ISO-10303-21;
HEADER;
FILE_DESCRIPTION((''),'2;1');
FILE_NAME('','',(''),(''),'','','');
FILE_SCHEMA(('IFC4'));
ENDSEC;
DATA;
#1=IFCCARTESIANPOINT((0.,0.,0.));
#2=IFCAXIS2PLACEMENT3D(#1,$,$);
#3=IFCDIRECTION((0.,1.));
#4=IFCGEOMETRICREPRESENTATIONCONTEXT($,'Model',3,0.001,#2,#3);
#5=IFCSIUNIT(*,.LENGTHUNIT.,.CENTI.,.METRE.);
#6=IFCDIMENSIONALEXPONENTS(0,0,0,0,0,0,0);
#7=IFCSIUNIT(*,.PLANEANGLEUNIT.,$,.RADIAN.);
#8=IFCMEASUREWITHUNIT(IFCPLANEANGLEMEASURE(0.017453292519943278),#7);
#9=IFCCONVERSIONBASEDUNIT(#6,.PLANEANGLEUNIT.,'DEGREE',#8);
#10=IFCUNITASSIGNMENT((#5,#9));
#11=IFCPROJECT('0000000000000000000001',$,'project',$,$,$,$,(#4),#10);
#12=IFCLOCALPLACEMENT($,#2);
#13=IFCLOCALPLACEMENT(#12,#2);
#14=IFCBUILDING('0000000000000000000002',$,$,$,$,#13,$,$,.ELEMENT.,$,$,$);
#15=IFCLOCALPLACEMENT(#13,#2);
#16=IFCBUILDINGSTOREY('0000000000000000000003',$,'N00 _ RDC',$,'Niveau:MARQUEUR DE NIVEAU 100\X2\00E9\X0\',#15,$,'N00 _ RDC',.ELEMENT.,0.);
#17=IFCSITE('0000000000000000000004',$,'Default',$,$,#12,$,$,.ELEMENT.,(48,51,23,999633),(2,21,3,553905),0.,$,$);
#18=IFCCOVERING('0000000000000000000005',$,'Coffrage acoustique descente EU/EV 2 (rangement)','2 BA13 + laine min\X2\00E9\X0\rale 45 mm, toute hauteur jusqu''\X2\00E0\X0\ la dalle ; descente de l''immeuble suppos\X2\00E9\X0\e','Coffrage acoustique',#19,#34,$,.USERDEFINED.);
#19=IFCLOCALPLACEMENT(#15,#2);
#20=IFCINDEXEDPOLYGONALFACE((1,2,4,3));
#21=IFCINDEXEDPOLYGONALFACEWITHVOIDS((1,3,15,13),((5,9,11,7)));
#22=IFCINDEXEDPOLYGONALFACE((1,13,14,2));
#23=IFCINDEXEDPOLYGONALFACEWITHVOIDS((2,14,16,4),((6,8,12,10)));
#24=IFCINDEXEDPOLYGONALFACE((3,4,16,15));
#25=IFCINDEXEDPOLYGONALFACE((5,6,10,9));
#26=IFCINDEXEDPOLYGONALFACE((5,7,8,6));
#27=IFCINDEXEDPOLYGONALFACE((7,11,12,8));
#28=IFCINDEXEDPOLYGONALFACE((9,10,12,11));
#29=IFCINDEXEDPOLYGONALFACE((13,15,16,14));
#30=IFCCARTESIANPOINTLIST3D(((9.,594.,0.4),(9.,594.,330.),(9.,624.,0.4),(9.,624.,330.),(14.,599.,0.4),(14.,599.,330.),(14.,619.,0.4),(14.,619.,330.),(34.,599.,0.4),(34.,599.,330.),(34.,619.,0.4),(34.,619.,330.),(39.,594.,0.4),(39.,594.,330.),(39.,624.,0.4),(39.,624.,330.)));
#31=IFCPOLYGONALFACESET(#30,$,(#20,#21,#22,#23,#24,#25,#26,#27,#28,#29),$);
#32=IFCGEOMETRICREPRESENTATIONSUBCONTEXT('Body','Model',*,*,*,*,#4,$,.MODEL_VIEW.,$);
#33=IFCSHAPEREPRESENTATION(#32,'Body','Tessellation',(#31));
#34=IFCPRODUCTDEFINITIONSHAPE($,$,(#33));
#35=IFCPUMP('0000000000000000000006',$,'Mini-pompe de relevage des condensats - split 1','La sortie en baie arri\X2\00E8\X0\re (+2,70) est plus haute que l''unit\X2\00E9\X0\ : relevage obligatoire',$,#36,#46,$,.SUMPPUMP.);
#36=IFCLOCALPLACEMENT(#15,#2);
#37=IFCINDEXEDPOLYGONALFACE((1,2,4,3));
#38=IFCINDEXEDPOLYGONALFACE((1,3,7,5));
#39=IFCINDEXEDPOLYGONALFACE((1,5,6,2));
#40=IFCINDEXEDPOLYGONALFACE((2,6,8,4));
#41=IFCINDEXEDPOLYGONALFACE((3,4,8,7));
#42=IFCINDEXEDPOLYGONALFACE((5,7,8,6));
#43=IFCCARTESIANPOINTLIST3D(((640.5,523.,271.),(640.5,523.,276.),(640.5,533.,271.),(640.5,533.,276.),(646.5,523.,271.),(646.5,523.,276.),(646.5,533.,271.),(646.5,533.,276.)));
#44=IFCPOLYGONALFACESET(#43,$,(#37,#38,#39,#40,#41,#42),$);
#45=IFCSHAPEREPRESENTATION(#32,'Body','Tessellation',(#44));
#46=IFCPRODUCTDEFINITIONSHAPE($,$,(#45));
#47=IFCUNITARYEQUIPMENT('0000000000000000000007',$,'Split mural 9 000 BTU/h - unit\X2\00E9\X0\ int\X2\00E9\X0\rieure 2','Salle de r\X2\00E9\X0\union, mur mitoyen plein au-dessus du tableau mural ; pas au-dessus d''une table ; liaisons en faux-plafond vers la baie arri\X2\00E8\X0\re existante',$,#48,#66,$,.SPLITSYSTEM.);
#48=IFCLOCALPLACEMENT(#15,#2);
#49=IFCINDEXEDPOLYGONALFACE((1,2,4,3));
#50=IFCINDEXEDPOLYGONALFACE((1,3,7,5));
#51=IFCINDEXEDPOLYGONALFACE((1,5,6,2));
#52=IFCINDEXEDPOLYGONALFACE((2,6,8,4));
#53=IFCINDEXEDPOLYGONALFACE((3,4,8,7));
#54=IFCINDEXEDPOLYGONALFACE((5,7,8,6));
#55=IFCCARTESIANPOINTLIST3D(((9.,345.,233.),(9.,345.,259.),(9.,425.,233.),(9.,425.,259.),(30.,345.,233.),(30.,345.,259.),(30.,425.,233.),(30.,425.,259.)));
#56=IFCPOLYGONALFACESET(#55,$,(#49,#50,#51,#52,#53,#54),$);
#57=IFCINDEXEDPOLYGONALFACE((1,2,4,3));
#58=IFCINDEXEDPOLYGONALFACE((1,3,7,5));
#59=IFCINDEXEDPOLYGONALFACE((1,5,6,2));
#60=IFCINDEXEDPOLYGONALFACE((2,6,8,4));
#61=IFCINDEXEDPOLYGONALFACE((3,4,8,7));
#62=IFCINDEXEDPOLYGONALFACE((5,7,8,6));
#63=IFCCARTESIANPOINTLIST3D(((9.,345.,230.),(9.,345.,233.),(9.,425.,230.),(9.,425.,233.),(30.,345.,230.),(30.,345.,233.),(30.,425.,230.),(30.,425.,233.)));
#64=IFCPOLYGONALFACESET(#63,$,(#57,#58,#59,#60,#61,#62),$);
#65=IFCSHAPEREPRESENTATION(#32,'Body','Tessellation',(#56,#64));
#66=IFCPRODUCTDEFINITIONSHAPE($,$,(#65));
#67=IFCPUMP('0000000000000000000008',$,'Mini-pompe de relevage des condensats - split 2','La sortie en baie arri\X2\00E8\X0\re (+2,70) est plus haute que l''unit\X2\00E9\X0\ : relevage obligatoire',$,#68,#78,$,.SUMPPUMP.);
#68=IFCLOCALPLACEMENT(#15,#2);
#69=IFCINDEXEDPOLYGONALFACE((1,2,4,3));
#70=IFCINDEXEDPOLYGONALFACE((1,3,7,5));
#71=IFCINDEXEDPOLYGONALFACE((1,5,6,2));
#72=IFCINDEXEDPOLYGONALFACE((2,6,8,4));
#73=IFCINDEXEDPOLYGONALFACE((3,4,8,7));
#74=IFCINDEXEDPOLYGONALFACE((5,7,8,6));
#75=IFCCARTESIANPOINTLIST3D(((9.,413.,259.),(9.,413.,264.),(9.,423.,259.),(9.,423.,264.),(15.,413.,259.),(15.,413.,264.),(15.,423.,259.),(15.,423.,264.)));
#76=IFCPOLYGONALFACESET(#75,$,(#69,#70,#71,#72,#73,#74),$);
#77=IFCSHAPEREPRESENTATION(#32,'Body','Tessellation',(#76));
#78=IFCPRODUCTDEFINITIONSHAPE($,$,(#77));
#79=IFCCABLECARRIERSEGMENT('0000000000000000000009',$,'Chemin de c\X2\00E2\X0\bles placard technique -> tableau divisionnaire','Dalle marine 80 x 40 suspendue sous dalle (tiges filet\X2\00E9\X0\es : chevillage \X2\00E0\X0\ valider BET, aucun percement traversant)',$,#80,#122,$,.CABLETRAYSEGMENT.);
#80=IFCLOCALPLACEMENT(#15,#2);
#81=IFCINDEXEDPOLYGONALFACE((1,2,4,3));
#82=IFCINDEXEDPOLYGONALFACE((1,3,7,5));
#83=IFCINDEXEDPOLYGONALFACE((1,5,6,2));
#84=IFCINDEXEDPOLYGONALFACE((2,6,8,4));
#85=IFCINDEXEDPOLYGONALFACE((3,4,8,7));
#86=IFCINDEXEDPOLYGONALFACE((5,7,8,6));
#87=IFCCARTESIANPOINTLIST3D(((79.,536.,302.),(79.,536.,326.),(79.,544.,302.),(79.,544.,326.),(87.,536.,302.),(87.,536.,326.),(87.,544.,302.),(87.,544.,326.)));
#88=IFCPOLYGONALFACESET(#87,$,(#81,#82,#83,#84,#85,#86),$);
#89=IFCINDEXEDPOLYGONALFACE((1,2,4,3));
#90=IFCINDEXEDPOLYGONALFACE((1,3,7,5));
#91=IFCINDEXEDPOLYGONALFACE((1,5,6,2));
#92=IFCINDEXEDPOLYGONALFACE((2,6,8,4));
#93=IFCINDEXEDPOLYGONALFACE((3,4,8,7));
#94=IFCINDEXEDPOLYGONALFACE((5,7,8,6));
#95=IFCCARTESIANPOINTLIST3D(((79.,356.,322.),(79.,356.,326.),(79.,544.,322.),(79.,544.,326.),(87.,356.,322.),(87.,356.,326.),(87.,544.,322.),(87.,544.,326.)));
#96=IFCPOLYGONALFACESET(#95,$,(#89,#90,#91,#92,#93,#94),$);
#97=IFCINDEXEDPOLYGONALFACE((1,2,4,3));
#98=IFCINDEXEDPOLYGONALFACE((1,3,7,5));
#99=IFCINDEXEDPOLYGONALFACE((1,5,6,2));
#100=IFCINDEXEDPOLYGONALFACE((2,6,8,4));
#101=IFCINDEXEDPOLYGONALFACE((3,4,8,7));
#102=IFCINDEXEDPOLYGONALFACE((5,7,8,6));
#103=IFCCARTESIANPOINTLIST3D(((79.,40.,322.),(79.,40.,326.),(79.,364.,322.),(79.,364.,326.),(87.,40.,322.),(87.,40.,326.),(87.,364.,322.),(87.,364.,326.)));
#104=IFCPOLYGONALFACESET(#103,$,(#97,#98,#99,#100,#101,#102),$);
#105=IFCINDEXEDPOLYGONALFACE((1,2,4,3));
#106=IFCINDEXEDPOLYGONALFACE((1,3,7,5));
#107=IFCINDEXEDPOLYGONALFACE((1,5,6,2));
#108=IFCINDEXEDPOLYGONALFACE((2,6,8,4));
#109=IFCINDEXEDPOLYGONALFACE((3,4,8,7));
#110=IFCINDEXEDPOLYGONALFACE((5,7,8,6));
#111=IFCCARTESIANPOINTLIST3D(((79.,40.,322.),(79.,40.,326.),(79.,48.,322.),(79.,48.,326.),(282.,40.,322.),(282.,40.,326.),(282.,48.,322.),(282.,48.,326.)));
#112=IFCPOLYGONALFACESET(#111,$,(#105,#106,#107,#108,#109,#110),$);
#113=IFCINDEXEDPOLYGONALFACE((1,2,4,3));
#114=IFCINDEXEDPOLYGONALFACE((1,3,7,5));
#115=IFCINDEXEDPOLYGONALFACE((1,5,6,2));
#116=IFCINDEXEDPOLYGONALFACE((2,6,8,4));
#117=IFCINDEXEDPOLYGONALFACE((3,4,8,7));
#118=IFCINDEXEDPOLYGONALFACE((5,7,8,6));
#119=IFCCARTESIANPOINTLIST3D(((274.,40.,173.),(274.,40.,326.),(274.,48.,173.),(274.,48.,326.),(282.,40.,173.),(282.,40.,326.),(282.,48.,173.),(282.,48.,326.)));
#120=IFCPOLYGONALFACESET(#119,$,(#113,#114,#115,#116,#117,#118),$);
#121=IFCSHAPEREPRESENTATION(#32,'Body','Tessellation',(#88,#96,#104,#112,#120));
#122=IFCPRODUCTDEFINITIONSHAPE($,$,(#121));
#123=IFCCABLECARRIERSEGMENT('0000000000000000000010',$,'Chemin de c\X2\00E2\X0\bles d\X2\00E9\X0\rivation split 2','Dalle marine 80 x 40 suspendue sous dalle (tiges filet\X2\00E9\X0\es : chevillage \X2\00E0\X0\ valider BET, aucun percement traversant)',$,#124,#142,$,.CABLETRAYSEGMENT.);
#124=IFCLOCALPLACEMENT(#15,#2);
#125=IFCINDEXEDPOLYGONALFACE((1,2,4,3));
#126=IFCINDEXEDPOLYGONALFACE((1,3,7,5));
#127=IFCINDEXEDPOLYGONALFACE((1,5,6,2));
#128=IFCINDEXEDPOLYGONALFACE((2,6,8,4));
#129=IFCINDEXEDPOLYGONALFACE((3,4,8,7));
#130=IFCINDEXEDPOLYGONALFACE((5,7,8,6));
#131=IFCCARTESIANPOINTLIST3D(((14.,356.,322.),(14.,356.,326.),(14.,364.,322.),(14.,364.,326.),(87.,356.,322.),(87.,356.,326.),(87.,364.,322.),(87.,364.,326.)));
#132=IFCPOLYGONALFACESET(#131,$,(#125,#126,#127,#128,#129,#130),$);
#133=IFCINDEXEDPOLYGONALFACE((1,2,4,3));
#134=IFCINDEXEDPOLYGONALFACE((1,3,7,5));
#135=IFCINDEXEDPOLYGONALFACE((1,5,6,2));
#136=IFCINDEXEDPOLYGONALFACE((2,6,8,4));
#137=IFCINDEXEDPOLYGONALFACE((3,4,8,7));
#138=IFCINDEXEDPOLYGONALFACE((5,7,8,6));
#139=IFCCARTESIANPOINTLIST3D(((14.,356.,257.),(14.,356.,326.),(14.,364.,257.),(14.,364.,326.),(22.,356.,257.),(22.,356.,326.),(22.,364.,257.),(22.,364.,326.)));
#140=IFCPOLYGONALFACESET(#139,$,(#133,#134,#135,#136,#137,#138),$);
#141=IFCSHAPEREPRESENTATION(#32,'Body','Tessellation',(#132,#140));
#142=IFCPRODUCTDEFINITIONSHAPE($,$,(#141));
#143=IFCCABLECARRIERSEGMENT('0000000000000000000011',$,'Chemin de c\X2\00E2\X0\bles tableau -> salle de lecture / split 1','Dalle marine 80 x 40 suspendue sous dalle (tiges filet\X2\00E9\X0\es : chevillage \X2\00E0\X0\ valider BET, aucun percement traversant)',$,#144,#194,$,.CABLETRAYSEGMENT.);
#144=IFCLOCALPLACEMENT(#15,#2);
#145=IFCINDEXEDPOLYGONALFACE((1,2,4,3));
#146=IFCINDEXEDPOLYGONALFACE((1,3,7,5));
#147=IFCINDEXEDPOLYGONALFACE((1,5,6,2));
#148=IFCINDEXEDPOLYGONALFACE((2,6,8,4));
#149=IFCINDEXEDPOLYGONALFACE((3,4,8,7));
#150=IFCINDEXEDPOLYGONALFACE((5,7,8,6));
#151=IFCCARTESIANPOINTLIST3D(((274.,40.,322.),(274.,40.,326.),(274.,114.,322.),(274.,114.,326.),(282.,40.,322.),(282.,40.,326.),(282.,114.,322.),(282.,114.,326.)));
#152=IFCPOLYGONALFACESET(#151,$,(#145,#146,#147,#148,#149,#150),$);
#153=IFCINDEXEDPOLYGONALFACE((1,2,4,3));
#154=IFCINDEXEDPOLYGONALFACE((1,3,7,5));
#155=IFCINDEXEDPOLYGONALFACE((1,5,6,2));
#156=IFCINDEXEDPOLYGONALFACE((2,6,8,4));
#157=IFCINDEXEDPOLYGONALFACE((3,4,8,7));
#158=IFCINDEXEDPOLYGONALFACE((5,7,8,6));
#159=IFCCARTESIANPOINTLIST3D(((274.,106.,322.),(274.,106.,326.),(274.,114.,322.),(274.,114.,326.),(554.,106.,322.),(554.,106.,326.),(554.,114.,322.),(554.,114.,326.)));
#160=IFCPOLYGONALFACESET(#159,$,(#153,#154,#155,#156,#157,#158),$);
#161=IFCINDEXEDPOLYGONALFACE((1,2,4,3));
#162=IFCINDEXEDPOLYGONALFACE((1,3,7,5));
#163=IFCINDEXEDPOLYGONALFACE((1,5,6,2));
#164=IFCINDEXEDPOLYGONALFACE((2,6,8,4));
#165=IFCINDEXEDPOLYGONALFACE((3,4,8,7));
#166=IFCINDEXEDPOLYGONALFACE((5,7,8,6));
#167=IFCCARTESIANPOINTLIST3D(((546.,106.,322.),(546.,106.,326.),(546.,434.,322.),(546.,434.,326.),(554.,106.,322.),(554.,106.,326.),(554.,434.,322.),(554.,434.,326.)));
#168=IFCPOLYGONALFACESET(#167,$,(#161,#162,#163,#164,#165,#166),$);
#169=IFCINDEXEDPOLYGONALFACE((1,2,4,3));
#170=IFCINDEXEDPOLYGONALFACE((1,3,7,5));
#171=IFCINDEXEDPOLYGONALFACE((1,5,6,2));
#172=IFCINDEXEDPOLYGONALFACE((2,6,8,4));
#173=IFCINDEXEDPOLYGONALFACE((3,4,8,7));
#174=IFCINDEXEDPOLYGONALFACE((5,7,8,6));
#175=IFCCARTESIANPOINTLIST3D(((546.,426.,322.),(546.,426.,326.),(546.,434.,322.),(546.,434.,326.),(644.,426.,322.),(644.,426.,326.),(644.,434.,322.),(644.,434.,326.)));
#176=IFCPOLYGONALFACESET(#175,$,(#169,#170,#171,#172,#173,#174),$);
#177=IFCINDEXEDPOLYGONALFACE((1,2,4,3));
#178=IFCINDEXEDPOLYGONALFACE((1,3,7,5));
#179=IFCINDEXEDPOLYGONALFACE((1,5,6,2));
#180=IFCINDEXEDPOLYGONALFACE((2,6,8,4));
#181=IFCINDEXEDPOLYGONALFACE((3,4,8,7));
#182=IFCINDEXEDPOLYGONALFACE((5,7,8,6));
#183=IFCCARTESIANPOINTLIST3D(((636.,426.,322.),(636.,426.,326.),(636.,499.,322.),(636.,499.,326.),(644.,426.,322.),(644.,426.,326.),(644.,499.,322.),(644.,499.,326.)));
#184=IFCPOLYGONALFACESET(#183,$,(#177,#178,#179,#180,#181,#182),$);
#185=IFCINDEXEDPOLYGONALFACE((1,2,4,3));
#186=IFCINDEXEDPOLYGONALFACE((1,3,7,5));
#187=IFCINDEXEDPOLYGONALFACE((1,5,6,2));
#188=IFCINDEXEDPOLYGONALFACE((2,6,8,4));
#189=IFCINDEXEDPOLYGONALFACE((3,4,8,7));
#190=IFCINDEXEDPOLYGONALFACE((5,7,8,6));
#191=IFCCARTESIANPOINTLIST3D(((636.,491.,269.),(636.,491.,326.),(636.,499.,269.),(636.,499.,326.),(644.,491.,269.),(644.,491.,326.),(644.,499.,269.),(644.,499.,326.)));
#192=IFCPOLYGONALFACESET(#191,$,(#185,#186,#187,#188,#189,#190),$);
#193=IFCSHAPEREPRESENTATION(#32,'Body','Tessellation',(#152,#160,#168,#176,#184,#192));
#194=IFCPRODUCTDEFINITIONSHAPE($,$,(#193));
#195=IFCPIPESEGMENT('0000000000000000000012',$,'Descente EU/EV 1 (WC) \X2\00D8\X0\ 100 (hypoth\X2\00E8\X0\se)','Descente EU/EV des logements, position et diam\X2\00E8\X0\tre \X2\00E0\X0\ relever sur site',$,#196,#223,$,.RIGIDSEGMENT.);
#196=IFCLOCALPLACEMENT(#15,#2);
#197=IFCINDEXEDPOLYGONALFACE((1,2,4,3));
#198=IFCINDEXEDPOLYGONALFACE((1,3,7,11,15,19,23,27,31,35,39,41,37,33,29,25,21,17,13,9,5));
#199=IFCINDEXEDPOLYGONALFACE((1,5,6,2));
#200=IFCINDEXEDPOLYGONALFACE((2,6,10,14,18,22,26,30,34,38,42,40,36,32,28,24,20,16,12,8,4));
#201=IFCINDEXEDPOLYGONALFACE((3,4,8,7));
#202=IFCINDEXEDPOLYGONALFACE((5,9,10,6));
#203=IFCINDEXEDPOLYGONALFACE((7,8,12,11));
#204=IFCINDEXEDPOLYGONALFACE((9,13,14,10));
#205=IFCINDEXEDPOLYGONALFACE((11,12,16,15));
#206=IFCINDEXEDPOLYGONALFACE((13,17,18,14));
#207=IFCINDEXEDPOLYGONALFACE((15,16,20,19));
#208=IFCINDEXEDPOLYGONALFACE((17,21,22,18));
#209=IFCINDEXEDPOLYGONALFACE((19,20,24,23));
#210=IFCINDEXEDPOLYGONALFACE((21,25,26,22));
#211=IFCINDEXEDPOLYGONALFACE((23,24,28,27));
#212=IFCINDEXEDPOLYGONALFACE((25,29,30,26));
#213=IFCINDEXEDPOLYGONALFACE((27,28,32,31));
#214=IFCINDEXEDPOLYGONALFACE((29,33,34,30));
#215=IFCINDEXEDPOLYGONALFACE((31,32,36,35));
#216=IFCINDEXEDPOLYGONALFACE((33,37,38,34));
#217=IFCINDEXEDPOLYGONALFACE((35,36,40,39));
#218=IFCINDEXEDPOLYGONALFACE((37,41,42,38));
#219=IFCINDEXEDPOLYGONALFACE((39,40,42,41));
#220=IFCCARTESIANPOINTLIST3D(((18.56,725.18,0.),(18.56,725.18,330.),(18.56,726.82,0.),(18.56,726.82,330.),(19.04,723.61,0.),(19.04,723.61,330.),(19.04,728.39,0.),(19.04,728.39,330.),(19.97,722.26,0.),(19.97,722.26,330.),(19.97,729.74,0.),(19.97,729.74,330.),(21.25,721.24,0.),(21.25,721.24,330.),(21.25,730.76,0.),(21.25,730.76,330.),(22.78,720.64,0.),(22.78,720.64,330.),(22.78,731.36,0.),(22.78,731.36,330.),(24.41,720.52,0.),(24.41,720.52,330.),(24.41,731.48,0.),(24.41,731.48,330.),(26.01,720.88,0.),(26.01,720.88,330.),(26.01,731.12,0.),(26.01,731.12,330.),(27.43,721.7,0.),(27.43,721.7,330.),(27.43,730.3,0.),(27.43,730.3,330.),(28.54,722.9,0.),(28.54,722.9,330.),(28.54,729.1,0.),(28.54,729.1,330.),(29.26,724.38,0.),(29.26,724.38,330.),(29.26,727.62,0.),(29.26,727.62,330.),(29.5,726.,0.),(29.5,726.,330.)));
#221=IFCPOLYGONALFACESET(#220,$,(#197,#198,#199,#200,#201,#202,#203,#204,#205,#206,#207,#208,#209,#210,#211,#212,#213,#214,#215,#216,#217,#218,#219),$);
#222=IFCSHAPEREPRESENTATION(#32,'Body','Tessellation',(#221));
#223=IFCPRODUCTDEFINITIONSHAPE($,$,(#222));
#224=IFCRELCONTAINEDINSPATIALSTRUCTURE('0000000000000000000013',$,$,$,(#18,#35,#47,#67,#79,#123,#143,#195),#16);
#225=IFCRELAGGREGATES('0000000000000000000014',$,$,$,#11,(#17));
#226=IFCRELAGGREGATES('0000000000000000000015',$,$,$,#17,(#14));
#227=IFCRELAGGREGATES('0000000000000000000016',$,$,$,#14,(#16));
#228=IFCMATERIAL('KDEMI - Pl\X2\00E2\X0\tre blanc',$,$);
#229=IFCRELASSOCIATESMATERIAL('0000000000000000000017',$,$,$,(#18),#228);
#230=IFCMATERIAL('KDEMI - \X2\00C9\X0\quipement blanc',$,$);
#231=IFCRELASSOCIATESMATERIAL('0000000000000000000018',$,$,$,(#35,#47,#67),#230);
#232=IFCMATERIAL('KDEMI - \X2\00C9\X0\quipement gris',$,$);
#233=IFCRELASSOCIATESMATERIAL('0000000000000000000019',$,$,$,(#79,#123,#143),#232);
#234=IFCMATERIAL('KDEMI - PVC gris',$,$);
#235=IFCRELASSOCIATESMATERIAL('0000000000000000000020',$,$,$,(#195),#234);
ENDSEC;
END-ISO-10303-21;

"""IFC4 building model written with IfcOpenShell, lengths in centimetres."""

from ifc_helpers import new_model, entity, si_unit, converted_unit, direction, frame, frame_2d, origin, origin_with_axes, place, context, subcontext, project, spatial, rectangle, hollow_rectangle, circle, extrude, material, element, save


model = new_model("IFC4")

# Units and contexts
model_context = context("Model", 3, precision=0.001, world=origin(), true_north=direction((0.0, 1.0)))
body_context = subcontext(model_context, "Body", "Model", "MODEL_VIEW")
ifc_project = project(units=[si_unit("LENGTHUNIT", "METRE", prefix="CENTI"), converted_unit("PLANEANGLEUNIT", "DEGREE", entity("IfcPlaneAngleMeasure", 0.017453292519943278), si_unit("PLANEANGLEUNIT", "RADIAN"), dimensions=[0, 0, 0, 0, 0, 0, 0])], contexts=[model_context])

# Site, building, storey
site_placement = place(None, origin())
site = spatial("IfcSite", under=ifc_project, at=site_placement, Name="Default", CompositionType="ELEMENT", RefLatitude=(48, 51, 23, 999633), RefLongitude=(2, 21, 3, 553905), RefElevation=0.0)
building_placement = place(site_placement, origin())
building = spatial("IfcBuilding", under=site, at=building_placement, CompositionType="ELEMENT")
storey_placement = place(building_placement, origin())
storey = spatial("IfcBuildingStorey", under=building, at=storey_placement, Name="N00 _ RDC", ObjectType="Niveau:MARQUEUR DE NIVEAU 100é", LongName="N00 _ RDC", CompositionType="ELEMENT", Elevation=0.0)

# Covering
ifc_material_1 = material(Name="KDEMI - Plâtre blanc")
covering_1_placement = place(storey_placement, origin_with_axes())
element("IfcCovering", 1, at=covering_1_placement, inside=storey, material=ifc_material_1, Name="Coffrage acoustique descente EU/EV 2 (rangement)", Description="2 BA13 + laine minérale 45 mm, toute hauteur jusqu'à la dalle ; descente de l'immeuble supposée", ObjectType="Coffrage acoustique", PredefinedType="USERDEFINED", context=body_context, shape_type="SweptSolid", body=[
    extrude(hollow_rectangle(XDim=30.0, YDim=30.0, WallThickness=5.0, at=frame_2d((24.0, 609.0))), frame((0.0, 0.0, 0.4)), (0.0, 0.0, 1.0), 329.6),
])

# Pump
ifc_material_2 = material(Name="KDEMI - Équipement blanc")
pump_1_placement = place(storey_placement, origin_with_axes())
element("IfcPump", 2, at=pump_1_placement, inside=storey, material=ifc_material_2, Name="Mini-pompe de relevage des condensats - split 1", Description="La sortie en baie arrière (+2,70) est plus haute que l'unité : relevage obligatoire", PredefinedType="SUMPPUMP", context=body_context, shape_type="SweptSolid", body=[
    extrude(rectangle(XDim=6.0, YDim=10.0, at=frame_2d((643.5, 528.0))), frame((0.0, 0.0, 271.0)), (0.0, 0.0, 1.0), 5.0),
])

# Unitary equipment
unitary_equipment_placement = place(storey_placement, origin_with_axes())
element("IfcUnitaryEquipment", 3, at=unitary_equipment_placement, inside=storey, material=ifc_material_2, Name="Split mural 9 000 BTU/h - unité intérieure 2", Description="Salle de réunion, mur mitoyen plein au-dessus du tableau mural ; pas au-dessus d'une table ; liaisons en faux-plafond vers la baie arrière existante", PredefinedType="SPLITSYSTEM", context=body_context, shape_type="SweptSolid", body=[
    extrude(rectangle(XDim=21.0, YDim=80.0, at=frame_2d((19.5, 385.0))), frame((0.0, 0.0, 233.0)), (0.0, 0.0, 1.0), 26.0),
    extrude(rectangle(XDim=21.0, YDim=80.0, at=frame_2d((19.5, 385.0))), frame((0.0, 0.0, 230.0)), (0.0, 0.0, 1.0), 3.0),
])

# Pump
pump_2_placement = place(storey_placement, origin_with_axes())
element("IfcPump", 4, at=pump_2_placement, inside=storey, material=ifc_material_2, Name="Mini-pompe de relevage des condensats - split 2", Description="La sortie en baie arrière (+2,70) est plus haute que l'unité : relevage obligatoire", PredefinedType="SUMPPUMP", context=body_context, shape_type="SweptSolid", body=[
    extrude(rectangle(XDim=6.0, YDim=10.0, at=frame_2d((12.0, 418.0))), frame((0.0, 0.0, 259.0)), (0.0, 0.0, 1.0), 5.0),
])

# Shared definitions
ifc_material_3 = material(Name="KDEMI - PVC gris")

# Cable carrier segments
ifc_material_4 = material(Name="KDEMI - Équipement gris")
cable_carrier_segment_1_placement = place(storey_placement, origin_with_axes())
element("IfcCableCarrierSegment", 5, at=cable_carrier_segment_1_placement, inside=storey, material=ifc_material_4, Name="Chemin de câbles placard technique -> tableau divisionnaire", Description="Dalle marine 80 x 40 suspendue sous dalle (tiges filetées : chevillage à valider BET, aucun percement traversant)", PredefinedType="CABLETRAYSEGMENT", context=body_context, shape_type="SweptSolid", body=[
    extrude(rectangle(XDim=8.0, YDim=8.0, at=frame_2d((83.0, 540.0))), frame((0.0, 0.0, 302.0)), (0.0, 0.0, 1.0), 24.0),
    extrude(rectangle(XDim=8.0, YDim=188.0, at=frame_2d((83.0, 450.0))), frame((0.0, 0.0, 322.0)), (0.0, 0.0, 1.0), 4.0),
    extrude(rectangle(XDim=8.0, YDim=324.0, at=frame_2d((83.0, 202.0))), frame((0.0, 0.0, 322.0)), (0.0, 0.0, 1.0), 4.0),
    extrude(rectangle(XDim=203.0, YDim=8.0, at=frame_2d((180.5, 44.0))), frame((0.0, 0.0, 322.0)), (0.0, 0.0, 1.0), 4.0),
    extrude(rectangle(XDim=8.0, YDim=8.0, at=frame_2d((278.0, 44.0))), frame((0.0, 0.0, 173.0)), (0.0, 0.0, 1.0), 153.0),
])
cable_carrier_segment_2_placement = place(storey_placement, origin_with_axes())
element("IfcCableCarrierSegment", 6, at=cable_carrier_segment_2_placement, inside=storey, material=ifc_material_4, Name="Chemin de câbles dérivation split 2", Description="Dalle marine 80 x 40 suspendue sous dalle (tiges filetées : chevillage à valider BET, aucun percement traversant)", PredefinedType="CABLETRAYSEGMENT", context=body_context, shape_type="SweptSolid", body=[
    extrude(rectangle(XDim=73.0, YDim=8.0, at=frame_2d((50.5, 360.0))), frame((0.0, 0.0, 322.0)), (0.0, 0.0, 1.0), 4.0),
    extrude(rectangle(XDim=8.0, YDim=8.0, at=frame_2d((18.0, 360.0))), frame((0.0, 0.0, 257.0)), (0.0, 0.0, 1.0), 69.0),
])
cable_carrier_segment_3_placement = place(storey_placement, origin_with_axes())
element("IfcCableCarrierSegment", 7, at=cable_carrier_segment_3_placement, inside=storey, material=ifc_material_4, Name="Chemin de câbles tableau -> salle de lecture / split 1", Description="Dalle marine 80 x 40 suspendue sous dalle (tiges filetées : chevillage à valider BET, aucun percement traversant)", PredefinedType="CABLETRAYSEGMENT", context=body_context, shape_type="SweptSolid", body=[
    extrude(rectangle(XDim=8.0, YDim=74.0, at=frame_2d((278.0, 77.0))), frame((0.0, 0.0, 322.0)), (0.0, 0.0, 1.0), 4.0),
    extrude(rectangle(XDim=280.0, YDim=8.0, at=frame_2d((414.0, 110.0))), frame((0.0, 0.0, 322.0)), (0.0, 0.0, 1.0), 4.0),
    extrude(rectangle(XDim=8.0, YDim=328.0, at=frame_2d((550.0, 270.0))), frame((0.0, 0.0, 322.0)), (0.0, 0.0, 1.0), 4.0),
    extrude(rectangle(XDim=98.0, YDim=8.0, at=frame_2d((595.0, 430.0))), frame((0.0, 0.0, 322.0)), (0.0, 0.0, 1.0), 4.0),
    extrude(rectangle(XDim=8.0, YDim=73.0, at=frame_2d((640.0, 462.5))), frame((0.0, 0.0, 322.0)), (0.0, 0.0, 1.0), 4.0),
    extrude(rectangle(XDim=8.0, YDim=8.0, at=frame_2d((640.0, 495.0))), frame((0.0, 0.0, 269.0)), (0.0, 0.0, 1.0), 57.0),
])

# Pipe segment
pipe_segment_1_placement = place(storey_placement, origin_with_axes())
element("IfcPipeSegment", 8, at=pipe_segment_1_placement, inside=storey, material=ifc_material_3, Name="Descente EU/EV 1 (WC) Ø 100 (hypothèse)", Description="Descente EU/EV des logements, position et diamètre à relever sur site", PredefinedType="RIGIDSEGMENT", context=body_context, shape_type="SweptSolid", body=[
    extrude(circle(Radius=5.5, at=frame_2d((24.0, 726.0))), origin(), (0.0, 0.0, 1.0), 330.0),
])

save(model, "model.ifc")
